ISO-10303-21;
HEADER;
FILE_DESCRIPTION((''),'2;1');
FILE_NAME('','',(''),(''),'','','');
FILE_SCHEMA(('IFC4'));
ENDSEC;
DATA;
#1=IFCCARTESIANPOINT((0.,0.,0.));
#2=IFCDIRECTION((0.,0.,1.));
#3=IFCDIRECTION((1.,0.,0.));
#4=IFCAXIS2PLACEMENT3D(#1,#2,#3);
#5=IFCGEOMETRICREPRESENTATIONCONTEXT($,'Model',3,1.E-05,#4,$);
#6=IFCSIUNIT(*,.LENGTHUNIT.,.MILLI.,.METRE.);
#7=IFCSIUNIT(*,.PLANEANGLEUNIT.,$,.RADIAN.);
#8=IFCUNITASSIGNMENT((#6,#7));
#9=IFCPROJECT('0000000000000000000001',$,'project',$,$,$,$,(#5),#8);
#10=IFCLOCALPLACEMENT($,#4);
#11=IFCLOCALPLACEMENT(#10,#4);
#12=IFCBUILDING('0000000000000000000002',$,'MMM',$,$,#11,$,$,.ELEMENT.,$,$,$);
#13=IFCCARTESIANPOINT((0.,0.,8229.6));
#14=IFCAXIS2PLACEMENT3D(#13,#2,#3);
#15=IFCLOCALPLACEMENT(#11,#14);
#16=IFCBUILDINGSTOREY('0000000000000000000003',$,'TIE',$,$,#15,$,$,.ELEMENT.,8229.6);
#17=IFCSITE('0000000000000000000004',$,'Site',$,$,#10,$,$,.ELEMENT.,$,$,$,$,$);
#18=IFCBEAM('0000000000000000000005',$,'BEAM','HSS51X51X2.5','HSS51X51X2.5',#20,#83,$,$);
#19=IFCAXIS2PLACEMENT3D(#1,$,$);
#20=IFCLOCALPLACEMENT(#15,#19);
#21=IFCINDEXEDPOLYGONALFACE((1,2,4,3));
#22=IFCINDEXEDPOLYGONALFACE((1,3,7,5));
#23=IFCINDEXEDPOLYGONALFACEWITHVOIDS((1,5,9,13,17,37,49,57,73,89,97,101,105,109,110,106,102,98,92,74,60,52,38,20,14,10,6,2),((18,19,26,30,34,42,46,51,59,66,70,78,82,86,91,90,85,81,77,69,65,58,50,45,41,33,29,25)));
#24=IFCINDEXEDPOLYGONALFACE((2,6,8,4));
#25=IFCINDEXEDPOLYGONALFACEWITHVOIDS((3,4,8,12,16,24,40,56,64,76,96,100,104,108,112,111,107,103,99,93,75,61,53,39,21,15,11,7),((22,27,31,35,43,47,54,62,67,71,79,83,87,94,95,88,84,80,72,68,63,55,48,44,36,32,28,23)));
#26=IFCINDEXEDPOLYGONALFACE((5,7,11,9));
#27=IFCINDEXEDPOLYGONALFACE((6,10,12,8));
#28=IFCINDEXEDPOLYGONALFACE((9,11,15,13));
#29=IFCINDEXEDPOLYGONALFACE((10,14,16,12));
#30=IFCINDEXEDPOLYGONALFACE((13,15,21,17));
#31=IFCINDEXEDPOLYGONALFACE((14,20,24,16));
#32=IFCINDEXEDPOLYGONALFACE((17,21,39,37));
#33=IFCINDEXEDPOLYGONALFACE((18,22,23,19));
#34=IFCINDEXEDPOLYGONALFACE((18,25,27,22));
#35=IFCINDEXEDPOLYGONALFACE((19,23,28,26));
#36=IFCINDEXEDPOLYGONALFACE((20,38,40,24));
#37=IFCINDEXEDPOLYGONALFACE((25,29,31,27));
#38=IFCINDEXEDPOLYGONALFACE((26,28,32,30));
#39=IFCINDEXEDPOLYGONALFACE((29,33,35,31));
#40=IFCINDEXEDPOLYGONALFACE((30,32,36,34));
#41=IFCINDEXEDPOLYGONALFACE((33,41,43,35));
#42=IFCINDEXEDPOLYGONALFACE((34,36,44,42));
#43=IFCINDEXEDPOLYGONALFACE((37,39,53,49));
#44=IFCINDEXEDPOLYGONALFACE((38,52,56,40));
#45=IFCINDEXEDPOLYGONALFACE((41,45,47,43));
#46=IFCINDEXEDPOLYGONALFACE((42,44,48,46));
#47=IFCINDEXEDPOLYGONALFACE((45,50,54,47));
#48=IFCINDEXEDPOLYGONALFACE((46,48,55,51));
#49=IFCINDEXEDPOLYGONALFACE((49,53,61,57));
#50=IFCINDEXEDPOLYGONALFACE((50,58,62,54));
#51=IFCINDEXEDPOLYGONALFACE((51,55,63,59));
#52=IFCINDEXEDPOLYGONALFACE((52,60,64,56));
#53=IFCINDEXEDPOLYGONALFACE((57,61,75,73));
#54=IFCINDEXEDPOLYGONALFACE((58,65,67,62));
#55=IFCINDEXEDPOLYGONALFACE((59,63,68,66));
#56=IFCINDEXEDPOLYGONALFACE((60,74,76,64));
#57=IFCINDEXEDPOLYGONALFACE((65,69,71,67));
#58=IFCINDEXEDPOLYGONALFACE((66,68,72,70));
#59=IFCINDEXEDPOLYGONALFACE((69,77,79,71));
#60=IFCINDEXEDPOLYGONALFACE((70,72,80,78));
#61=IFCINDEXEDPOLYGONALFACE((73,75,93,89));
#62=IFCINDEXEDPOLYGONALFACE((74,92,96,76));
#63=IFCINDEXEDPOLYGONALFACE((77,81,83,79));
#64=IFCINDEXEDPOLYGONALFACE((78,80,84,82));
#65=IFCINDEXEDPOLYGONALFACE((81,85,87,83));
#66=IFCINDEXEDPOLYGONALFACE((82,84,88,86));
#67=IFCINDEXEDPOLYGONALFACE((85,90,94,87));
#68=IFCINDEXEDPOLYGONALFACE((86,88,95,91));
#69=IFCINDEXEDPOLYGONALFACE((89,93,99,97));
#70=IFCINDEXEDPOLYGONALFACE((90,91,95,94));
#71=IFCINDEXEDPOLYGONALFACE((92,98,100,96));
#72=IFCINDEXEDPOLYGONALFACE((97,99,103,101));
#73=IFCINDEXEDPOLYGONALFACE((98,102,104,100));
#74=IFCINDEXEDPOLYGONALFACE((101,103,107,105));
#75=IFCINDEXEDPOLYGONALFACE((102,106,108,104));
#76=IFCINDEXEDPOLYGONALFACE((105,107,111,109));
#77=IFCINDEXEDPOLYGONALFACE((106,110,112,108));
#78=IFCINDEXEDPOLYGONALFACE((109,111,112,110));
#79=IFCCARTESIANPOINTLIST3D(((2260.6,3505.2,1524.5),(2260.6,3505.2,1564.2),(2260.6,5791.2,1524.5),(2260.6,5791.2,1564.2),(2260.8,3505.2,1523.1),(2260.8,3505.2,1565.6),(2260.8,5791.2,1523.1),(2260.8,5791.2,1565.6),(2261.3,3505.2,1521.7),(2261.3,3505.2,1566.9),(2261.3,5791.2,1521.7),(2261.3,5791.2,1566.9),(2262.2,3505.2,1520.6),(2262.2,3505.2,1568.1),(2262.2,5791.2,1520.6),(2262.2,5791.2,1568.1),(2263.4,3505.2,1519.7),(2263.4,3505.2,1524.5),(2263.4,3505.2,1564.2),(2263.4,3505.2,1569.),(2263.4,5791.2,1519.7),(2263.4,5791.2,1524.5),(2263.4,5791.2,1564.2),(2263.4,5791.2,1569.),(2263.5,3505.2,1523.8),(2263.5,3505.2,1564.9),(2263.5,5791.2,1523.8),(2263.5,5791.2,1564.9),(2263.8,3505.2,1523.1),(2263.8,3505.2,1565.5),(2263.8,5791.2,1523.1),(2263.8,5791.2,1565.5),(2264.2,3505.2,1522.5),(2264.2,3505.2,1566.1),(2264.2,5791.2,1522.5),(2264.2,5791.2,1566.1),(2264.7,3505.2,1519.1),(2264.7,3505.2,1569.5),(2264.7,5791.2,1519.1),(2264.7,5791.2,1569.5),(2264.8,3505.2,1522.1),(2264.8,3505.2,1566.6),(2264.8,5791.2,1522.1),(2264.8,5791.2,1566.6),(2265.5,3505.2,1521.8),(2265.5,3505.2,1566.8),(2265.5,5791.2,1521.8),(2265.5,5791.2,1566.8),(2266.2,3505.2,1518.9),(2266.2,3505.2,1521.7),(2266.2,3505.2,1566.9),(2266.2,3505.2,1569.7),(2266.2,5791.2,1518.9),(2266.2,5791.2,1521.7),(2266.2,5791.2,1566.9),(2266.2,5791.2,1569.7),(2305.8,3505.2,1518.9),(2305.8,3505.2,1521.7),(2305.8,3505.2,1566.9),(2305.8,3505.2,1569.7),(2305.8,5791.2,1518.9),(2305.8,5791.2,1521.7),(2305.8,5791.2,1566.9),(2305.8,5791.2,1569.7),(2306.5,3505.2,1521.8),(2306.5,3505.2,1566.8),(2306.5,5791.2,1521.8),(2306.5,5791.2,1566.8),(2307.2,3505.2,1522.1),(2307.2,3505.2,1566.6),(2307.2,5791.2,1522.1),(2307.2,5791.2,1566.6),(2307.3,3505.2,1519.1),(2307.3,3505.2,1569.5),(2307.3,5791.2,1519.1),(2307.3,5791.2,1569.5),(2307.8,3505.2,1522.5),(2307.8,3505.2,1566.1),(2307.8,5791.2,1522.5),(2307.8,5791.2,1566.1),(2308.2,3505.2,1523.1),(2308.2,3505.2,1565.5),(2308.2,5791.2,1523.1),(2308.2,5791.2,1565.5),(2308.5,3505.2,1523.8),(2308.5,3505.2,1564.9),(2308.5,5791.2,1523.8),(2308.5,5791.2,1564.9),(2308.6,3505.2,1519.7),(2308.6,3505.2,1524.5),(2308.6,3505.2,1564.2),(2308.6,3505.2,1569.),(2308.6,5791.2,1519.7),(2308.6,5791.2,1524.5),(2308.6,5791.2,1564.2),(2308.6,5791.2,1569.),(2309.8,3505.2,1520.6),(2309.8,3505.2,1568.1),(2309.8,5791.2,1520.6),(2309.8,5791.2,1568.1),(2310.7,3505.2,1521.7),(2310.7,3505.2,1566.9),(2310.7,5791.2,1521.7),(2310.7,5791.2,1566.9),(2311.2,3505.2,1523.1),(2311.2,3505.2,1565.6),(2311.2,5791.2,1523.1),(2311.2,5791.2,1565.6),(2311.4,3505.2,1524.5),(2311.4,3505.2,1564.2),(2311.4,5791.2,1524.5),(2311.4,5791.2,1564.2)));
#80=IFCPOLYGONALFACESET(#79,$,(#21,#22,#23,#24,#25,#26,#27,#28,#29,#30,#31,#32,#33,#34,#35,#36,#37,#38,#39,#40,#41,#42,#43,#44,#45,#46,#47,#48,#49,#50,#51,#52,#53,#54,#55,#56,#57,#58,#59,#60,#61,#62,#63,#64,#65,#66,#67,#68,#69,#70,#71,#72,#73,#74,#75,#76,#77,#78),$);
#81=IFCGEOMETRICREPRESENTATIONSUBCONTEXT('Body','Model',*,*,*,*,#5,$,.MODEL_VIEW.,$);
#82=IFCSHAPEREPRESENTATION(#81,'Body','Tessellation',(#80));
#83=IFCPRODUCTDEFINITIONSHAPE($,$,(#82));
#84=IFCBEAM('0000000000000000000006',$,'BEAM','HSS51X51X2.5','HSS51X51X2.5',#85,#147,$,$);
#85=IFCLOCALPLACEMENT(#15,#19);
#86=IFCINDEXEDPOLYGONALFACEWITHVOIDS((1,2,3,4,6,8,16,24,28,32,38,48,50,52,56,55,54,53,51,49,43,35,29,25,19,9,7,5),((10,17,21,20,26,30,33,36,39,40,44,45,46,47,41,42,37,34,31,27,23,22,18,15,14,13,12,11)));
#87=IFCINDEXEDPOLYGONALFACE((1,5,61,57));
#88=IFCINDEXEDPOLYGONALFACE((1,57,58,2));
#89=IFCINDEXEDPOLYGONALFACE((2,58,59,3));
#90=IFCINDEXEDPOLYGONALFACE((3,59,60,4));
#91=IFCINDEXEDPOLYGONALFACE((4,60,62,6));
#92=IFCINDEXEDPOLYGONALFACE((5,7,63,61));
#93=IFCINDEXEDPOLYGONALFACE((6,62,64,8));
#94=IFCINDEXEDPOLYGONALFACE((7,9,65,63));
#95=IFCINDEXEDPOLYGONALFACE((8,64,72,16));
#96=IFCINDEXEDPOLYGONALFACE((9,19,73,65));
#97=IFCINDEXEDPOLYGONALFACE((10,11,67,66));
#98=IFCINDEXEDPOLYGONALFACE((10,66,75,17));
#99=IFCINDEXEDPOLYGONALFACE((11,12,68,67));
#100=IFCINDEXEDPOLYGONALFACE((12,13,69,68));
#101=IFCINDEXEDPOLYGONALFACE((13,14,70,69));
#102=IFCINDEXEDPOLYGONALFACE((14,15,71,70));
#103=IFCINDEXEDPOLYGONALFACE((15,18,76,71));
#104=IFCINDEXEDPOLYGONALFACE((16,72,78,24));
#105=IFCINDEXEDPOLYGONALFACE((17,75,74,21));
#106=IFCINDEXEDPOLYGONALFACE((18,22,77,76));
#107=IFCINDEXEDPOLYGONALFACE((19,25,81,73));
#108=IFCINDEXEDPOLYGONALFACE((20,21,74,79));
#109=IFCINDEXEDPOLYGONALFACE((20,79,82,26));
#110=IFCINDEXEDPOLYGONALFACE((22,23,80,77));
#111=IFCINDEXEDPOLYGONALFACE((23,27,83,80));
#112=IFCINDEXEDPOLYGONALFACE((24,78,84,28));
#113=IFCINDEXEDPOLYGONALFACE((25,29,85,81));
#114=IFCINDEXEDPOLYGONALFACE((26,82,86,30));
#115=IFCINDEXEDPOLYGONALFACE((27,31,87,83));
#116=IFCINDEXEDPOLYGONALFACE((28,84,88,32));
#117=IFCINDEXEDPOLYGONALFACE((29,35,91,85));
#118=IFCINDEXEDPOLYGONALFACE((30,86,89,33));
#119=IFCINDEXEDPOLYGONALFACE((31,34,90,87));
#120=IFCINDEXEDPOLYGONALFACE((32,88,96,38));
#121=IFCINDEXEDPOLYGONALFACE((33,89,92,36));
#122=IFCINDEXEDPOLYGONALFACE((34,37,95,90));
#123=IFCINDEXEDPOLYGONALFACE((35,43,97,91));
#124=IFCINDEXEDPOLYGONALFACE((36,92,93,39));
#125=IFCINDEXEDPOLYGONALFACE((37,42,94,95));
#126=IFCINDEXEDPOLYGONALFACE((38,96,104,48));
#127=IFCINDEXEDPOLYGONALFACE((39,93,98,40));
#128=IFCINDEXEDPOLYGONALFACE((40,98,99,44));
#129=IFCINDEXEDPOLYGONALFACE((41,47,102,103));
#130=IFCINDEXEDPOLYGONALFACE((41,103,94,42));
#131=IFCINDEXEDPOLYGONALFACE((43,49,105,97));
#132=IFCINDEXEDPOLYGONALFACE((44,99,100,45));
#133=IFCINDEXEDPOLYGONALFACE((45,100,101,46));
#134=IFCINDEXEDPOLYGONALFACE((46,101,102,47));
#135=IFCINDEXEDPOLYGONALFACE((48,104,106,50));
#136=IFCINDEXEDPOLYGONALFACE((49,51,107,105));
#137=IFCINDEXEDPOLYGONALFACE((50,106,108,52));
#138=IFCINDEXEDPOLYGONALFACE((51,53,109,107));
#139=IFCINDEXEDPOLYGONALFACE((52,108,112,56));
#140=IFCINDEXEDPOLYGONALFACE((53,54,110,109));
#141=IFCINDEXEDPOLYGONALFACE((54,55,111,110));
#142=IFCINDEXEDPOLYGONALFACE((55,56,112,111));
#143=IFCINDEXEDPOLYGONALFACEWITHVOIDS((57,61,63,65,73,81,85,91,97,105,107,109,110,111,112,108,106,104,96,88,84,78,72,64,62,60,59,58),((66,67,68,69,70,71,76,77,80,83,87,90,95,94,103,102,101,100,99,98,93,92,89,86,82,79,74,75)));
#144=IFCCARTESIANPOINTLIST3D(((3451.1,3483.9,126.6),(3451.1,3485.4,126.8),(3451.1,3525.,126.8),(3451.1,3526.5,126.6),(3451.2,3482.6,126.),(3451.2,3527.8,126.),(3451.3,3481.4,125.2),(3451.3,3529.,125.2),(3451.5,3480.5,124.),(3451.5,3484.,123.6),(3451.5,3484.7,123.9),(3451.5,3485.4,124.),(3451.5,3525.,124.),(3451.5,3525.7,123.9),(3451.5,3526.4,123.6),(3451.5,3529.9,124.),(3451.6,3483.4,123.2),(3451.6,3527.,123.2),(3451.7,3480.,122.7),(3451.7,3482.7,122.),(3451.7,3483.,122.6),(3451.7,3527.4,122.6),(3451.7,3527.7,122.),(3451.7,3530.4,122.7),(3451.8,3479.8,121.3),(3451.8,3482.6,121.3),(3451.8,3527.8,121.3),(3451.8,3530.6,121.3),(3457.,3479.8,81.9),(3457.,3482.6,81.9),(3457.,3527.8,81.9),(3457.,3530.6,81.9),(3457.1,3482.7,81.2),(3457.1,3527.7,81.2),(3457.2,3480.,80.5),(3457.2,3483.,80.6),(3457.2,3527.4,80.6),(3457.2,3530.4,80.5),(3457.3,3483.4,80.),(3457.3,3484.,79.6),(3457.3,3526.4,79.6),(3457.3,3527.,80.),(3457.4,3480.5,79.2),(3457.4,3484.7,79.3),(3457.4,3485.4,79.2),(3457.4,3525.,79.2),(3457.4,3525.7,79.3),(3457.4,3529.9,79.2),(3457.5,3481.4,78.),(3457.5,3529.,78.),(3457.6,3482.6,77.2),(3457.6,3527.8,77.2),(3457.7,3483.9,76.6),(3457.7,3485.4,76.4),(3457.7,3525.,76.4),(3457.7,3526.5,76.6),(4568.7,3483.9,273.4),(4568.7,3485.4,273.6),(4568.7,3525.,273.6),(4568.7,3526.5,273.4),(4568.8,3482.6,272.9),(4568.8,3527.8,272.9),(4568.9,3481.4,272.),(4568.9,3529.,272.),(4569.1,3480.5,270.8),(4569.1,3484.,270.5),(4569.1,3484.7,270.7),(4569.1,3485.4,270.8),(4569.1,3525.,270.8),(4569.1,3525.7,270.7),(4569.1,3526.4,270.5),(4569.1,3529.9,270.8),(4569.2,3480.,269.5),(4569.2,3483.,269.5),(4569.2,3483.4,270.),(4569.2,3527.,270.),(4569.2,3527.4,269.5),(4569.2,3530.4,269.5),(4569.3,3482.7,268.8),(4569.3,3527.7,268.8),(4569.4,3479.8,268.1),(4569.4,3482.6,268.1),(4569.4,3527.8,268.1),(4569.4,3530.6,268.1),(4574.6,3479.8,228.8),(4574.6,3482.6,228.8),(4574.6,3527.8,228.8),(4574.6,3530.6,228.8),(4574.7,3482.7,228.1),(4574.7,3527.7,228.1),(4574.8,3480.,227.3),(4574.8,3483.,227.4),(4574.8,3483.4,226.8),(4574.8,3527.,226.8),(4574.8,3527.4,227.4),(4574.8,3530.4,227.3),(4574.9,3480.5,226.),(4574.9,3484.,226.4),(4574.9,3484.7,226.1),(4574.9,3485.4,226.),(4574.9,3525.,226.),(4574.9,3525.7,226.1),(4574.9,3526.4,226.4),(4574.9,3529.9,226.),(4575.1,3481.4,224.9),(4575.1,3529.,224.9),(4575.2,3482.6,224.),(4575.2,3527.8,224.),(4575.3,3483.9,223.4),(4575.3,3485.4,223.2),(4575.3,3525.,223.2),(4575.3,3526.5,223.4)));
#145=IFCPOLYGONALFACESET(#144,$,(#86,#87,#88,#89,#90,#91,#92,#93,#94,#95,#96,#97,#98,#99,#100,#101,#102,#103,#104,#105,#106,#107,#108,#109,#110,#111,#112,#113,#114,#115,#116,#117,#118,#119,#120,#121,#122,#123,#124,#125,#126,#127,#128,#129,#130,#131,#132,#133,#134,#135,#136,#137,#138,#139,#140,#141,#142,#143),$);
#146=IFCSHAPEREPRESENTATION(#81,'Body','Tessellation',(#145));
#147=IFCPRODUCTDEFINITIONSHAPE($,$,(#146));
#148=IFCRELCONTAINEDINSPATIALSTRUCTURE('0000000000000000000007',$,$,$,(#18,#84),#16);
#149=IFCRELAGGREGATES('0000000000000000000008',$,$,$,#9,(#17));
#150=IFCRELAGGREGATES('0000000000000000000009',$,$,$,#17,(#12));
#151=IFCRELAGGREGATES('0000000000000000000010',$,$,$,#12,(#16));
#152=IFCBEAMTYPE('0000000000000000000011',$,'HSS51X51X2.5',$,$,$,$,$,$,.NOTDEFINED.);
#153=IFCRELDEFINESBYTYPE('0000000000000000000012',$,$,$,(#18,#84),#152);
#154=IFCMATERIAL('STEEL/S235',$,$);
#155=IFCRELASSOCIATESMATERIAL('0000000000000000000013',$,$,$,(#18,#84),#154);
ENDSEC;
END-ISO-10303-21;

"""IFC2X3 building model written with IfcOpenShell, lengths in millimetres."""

from ifc_helpers import new_model, si_unit, frame, origin_with_axes, origin_2d_with_axis, place, context, subcontext, project, spatial, hollow_rectangle, extrude, material, type_object, element, save


model = new_model("IFC2X3")

# Units and contexts
model_context = context("Model", 3, precision=1e-05, world=origin_with_axes())
body_context = subcontext(model_context, "Body", "Model", "MODEL_VIEW")
ifc_project = project(units=[si_unit("LENGTHUNIT", "METRE", prefix="MILLI"), si_unit("PLANEANGLEUNIT", "RADIAN")], contexts=[model_context])

# Site, building, storey
site_placement = place(None, origin_with_axes())
site = spatial("IfcSite", under=ifc_project, at=site_placement, Name="Site", CompositionType="ELEMENT")
building_placement = place(site_placement, origin_with_axes())
building = spatial("IfcBuilding", under=site, at=building_placement, Name="MMM", CompositionType="ELEMENT")
storey_placement = place(building_placement, frame((0.0, 0.0, 8229.6), z_axis=(0.0, 0.0, 1.0), x_axis=(1.0, 0.0, 0.0)))
storey = spatial("IfcBuildingStorey", under=building, at=storey_placement, Name="TIE", CompositionType="ELEMENT", Elevation=8229.6)

# Beams
ifc_material = material(Name="STEEL/S235")
beam_type_1 = type_object("IfcBeamType", Name="HSS51X51X2.5", PredefinedType="NOTDEFINED")
beam_1_placement = place(storey_placement, frame((2286.0, 3505.2, 1544.3), z_axis=(0.0, 0.0, 1.0), x_axis=(0.0, 1.0, 0.0)))
element("IfcBeam", 1, at=beam_1_placement, inside=storey, type_object=beam_type_1, material=ifc_material, Name="BEAM", Description="HSS51X51X2.5", ObjectType="HSS51X51X2.5", context=body_context, shape_type="SweptSolid", body=[
    extrude(hollow_rectangle(XDim=50.8, YDim=50.8, WallThickness=2.8, InnerFilletRadius=2.8, OuterFilletRadius=5.6, at=origin_2d_with_axis()), frame((2286.0, 0.0, 0.0), z_axis=(-1.0, 0.0, 0.0), x_axis=(0.0, -1.0, 0.0)), (0.0, 0.0, 1.0), 2286.0),
])
beam_2_placement = place(storey_placement, frame((3454.4, 3505.2, 101.6), z_axis=(-0.130258, 0.0, 0.99148), x_axis=(0.99148, 0.0, 0.130258)))
element("IfcBeam", 2, at=beam_2_placement, inside=storey, type_object=beam_type_1, material=ifc_material, Name="BEAM", Description="HSS51X51X2.5", ObjectType="HSS51X51X2.5", context=body_context, shape_type="SweptSolid", body=[
    extrude(hollow_rectangle(XDim=50.8, YDim=50.8, WallThickness=2.8, InnerFilletRadius=2.8, OuterFilletRadius=5.6, at=origin_2d_with_axis()), frame((1127.2, 0.0, 0.0), z_axis=(-1.0, 0.0, 0.0), x_axis=(0.0, -1.0, 0.0)), (0.0, 0.0, 1.0), 1127.2),
])

save(model, "model.ifc")
